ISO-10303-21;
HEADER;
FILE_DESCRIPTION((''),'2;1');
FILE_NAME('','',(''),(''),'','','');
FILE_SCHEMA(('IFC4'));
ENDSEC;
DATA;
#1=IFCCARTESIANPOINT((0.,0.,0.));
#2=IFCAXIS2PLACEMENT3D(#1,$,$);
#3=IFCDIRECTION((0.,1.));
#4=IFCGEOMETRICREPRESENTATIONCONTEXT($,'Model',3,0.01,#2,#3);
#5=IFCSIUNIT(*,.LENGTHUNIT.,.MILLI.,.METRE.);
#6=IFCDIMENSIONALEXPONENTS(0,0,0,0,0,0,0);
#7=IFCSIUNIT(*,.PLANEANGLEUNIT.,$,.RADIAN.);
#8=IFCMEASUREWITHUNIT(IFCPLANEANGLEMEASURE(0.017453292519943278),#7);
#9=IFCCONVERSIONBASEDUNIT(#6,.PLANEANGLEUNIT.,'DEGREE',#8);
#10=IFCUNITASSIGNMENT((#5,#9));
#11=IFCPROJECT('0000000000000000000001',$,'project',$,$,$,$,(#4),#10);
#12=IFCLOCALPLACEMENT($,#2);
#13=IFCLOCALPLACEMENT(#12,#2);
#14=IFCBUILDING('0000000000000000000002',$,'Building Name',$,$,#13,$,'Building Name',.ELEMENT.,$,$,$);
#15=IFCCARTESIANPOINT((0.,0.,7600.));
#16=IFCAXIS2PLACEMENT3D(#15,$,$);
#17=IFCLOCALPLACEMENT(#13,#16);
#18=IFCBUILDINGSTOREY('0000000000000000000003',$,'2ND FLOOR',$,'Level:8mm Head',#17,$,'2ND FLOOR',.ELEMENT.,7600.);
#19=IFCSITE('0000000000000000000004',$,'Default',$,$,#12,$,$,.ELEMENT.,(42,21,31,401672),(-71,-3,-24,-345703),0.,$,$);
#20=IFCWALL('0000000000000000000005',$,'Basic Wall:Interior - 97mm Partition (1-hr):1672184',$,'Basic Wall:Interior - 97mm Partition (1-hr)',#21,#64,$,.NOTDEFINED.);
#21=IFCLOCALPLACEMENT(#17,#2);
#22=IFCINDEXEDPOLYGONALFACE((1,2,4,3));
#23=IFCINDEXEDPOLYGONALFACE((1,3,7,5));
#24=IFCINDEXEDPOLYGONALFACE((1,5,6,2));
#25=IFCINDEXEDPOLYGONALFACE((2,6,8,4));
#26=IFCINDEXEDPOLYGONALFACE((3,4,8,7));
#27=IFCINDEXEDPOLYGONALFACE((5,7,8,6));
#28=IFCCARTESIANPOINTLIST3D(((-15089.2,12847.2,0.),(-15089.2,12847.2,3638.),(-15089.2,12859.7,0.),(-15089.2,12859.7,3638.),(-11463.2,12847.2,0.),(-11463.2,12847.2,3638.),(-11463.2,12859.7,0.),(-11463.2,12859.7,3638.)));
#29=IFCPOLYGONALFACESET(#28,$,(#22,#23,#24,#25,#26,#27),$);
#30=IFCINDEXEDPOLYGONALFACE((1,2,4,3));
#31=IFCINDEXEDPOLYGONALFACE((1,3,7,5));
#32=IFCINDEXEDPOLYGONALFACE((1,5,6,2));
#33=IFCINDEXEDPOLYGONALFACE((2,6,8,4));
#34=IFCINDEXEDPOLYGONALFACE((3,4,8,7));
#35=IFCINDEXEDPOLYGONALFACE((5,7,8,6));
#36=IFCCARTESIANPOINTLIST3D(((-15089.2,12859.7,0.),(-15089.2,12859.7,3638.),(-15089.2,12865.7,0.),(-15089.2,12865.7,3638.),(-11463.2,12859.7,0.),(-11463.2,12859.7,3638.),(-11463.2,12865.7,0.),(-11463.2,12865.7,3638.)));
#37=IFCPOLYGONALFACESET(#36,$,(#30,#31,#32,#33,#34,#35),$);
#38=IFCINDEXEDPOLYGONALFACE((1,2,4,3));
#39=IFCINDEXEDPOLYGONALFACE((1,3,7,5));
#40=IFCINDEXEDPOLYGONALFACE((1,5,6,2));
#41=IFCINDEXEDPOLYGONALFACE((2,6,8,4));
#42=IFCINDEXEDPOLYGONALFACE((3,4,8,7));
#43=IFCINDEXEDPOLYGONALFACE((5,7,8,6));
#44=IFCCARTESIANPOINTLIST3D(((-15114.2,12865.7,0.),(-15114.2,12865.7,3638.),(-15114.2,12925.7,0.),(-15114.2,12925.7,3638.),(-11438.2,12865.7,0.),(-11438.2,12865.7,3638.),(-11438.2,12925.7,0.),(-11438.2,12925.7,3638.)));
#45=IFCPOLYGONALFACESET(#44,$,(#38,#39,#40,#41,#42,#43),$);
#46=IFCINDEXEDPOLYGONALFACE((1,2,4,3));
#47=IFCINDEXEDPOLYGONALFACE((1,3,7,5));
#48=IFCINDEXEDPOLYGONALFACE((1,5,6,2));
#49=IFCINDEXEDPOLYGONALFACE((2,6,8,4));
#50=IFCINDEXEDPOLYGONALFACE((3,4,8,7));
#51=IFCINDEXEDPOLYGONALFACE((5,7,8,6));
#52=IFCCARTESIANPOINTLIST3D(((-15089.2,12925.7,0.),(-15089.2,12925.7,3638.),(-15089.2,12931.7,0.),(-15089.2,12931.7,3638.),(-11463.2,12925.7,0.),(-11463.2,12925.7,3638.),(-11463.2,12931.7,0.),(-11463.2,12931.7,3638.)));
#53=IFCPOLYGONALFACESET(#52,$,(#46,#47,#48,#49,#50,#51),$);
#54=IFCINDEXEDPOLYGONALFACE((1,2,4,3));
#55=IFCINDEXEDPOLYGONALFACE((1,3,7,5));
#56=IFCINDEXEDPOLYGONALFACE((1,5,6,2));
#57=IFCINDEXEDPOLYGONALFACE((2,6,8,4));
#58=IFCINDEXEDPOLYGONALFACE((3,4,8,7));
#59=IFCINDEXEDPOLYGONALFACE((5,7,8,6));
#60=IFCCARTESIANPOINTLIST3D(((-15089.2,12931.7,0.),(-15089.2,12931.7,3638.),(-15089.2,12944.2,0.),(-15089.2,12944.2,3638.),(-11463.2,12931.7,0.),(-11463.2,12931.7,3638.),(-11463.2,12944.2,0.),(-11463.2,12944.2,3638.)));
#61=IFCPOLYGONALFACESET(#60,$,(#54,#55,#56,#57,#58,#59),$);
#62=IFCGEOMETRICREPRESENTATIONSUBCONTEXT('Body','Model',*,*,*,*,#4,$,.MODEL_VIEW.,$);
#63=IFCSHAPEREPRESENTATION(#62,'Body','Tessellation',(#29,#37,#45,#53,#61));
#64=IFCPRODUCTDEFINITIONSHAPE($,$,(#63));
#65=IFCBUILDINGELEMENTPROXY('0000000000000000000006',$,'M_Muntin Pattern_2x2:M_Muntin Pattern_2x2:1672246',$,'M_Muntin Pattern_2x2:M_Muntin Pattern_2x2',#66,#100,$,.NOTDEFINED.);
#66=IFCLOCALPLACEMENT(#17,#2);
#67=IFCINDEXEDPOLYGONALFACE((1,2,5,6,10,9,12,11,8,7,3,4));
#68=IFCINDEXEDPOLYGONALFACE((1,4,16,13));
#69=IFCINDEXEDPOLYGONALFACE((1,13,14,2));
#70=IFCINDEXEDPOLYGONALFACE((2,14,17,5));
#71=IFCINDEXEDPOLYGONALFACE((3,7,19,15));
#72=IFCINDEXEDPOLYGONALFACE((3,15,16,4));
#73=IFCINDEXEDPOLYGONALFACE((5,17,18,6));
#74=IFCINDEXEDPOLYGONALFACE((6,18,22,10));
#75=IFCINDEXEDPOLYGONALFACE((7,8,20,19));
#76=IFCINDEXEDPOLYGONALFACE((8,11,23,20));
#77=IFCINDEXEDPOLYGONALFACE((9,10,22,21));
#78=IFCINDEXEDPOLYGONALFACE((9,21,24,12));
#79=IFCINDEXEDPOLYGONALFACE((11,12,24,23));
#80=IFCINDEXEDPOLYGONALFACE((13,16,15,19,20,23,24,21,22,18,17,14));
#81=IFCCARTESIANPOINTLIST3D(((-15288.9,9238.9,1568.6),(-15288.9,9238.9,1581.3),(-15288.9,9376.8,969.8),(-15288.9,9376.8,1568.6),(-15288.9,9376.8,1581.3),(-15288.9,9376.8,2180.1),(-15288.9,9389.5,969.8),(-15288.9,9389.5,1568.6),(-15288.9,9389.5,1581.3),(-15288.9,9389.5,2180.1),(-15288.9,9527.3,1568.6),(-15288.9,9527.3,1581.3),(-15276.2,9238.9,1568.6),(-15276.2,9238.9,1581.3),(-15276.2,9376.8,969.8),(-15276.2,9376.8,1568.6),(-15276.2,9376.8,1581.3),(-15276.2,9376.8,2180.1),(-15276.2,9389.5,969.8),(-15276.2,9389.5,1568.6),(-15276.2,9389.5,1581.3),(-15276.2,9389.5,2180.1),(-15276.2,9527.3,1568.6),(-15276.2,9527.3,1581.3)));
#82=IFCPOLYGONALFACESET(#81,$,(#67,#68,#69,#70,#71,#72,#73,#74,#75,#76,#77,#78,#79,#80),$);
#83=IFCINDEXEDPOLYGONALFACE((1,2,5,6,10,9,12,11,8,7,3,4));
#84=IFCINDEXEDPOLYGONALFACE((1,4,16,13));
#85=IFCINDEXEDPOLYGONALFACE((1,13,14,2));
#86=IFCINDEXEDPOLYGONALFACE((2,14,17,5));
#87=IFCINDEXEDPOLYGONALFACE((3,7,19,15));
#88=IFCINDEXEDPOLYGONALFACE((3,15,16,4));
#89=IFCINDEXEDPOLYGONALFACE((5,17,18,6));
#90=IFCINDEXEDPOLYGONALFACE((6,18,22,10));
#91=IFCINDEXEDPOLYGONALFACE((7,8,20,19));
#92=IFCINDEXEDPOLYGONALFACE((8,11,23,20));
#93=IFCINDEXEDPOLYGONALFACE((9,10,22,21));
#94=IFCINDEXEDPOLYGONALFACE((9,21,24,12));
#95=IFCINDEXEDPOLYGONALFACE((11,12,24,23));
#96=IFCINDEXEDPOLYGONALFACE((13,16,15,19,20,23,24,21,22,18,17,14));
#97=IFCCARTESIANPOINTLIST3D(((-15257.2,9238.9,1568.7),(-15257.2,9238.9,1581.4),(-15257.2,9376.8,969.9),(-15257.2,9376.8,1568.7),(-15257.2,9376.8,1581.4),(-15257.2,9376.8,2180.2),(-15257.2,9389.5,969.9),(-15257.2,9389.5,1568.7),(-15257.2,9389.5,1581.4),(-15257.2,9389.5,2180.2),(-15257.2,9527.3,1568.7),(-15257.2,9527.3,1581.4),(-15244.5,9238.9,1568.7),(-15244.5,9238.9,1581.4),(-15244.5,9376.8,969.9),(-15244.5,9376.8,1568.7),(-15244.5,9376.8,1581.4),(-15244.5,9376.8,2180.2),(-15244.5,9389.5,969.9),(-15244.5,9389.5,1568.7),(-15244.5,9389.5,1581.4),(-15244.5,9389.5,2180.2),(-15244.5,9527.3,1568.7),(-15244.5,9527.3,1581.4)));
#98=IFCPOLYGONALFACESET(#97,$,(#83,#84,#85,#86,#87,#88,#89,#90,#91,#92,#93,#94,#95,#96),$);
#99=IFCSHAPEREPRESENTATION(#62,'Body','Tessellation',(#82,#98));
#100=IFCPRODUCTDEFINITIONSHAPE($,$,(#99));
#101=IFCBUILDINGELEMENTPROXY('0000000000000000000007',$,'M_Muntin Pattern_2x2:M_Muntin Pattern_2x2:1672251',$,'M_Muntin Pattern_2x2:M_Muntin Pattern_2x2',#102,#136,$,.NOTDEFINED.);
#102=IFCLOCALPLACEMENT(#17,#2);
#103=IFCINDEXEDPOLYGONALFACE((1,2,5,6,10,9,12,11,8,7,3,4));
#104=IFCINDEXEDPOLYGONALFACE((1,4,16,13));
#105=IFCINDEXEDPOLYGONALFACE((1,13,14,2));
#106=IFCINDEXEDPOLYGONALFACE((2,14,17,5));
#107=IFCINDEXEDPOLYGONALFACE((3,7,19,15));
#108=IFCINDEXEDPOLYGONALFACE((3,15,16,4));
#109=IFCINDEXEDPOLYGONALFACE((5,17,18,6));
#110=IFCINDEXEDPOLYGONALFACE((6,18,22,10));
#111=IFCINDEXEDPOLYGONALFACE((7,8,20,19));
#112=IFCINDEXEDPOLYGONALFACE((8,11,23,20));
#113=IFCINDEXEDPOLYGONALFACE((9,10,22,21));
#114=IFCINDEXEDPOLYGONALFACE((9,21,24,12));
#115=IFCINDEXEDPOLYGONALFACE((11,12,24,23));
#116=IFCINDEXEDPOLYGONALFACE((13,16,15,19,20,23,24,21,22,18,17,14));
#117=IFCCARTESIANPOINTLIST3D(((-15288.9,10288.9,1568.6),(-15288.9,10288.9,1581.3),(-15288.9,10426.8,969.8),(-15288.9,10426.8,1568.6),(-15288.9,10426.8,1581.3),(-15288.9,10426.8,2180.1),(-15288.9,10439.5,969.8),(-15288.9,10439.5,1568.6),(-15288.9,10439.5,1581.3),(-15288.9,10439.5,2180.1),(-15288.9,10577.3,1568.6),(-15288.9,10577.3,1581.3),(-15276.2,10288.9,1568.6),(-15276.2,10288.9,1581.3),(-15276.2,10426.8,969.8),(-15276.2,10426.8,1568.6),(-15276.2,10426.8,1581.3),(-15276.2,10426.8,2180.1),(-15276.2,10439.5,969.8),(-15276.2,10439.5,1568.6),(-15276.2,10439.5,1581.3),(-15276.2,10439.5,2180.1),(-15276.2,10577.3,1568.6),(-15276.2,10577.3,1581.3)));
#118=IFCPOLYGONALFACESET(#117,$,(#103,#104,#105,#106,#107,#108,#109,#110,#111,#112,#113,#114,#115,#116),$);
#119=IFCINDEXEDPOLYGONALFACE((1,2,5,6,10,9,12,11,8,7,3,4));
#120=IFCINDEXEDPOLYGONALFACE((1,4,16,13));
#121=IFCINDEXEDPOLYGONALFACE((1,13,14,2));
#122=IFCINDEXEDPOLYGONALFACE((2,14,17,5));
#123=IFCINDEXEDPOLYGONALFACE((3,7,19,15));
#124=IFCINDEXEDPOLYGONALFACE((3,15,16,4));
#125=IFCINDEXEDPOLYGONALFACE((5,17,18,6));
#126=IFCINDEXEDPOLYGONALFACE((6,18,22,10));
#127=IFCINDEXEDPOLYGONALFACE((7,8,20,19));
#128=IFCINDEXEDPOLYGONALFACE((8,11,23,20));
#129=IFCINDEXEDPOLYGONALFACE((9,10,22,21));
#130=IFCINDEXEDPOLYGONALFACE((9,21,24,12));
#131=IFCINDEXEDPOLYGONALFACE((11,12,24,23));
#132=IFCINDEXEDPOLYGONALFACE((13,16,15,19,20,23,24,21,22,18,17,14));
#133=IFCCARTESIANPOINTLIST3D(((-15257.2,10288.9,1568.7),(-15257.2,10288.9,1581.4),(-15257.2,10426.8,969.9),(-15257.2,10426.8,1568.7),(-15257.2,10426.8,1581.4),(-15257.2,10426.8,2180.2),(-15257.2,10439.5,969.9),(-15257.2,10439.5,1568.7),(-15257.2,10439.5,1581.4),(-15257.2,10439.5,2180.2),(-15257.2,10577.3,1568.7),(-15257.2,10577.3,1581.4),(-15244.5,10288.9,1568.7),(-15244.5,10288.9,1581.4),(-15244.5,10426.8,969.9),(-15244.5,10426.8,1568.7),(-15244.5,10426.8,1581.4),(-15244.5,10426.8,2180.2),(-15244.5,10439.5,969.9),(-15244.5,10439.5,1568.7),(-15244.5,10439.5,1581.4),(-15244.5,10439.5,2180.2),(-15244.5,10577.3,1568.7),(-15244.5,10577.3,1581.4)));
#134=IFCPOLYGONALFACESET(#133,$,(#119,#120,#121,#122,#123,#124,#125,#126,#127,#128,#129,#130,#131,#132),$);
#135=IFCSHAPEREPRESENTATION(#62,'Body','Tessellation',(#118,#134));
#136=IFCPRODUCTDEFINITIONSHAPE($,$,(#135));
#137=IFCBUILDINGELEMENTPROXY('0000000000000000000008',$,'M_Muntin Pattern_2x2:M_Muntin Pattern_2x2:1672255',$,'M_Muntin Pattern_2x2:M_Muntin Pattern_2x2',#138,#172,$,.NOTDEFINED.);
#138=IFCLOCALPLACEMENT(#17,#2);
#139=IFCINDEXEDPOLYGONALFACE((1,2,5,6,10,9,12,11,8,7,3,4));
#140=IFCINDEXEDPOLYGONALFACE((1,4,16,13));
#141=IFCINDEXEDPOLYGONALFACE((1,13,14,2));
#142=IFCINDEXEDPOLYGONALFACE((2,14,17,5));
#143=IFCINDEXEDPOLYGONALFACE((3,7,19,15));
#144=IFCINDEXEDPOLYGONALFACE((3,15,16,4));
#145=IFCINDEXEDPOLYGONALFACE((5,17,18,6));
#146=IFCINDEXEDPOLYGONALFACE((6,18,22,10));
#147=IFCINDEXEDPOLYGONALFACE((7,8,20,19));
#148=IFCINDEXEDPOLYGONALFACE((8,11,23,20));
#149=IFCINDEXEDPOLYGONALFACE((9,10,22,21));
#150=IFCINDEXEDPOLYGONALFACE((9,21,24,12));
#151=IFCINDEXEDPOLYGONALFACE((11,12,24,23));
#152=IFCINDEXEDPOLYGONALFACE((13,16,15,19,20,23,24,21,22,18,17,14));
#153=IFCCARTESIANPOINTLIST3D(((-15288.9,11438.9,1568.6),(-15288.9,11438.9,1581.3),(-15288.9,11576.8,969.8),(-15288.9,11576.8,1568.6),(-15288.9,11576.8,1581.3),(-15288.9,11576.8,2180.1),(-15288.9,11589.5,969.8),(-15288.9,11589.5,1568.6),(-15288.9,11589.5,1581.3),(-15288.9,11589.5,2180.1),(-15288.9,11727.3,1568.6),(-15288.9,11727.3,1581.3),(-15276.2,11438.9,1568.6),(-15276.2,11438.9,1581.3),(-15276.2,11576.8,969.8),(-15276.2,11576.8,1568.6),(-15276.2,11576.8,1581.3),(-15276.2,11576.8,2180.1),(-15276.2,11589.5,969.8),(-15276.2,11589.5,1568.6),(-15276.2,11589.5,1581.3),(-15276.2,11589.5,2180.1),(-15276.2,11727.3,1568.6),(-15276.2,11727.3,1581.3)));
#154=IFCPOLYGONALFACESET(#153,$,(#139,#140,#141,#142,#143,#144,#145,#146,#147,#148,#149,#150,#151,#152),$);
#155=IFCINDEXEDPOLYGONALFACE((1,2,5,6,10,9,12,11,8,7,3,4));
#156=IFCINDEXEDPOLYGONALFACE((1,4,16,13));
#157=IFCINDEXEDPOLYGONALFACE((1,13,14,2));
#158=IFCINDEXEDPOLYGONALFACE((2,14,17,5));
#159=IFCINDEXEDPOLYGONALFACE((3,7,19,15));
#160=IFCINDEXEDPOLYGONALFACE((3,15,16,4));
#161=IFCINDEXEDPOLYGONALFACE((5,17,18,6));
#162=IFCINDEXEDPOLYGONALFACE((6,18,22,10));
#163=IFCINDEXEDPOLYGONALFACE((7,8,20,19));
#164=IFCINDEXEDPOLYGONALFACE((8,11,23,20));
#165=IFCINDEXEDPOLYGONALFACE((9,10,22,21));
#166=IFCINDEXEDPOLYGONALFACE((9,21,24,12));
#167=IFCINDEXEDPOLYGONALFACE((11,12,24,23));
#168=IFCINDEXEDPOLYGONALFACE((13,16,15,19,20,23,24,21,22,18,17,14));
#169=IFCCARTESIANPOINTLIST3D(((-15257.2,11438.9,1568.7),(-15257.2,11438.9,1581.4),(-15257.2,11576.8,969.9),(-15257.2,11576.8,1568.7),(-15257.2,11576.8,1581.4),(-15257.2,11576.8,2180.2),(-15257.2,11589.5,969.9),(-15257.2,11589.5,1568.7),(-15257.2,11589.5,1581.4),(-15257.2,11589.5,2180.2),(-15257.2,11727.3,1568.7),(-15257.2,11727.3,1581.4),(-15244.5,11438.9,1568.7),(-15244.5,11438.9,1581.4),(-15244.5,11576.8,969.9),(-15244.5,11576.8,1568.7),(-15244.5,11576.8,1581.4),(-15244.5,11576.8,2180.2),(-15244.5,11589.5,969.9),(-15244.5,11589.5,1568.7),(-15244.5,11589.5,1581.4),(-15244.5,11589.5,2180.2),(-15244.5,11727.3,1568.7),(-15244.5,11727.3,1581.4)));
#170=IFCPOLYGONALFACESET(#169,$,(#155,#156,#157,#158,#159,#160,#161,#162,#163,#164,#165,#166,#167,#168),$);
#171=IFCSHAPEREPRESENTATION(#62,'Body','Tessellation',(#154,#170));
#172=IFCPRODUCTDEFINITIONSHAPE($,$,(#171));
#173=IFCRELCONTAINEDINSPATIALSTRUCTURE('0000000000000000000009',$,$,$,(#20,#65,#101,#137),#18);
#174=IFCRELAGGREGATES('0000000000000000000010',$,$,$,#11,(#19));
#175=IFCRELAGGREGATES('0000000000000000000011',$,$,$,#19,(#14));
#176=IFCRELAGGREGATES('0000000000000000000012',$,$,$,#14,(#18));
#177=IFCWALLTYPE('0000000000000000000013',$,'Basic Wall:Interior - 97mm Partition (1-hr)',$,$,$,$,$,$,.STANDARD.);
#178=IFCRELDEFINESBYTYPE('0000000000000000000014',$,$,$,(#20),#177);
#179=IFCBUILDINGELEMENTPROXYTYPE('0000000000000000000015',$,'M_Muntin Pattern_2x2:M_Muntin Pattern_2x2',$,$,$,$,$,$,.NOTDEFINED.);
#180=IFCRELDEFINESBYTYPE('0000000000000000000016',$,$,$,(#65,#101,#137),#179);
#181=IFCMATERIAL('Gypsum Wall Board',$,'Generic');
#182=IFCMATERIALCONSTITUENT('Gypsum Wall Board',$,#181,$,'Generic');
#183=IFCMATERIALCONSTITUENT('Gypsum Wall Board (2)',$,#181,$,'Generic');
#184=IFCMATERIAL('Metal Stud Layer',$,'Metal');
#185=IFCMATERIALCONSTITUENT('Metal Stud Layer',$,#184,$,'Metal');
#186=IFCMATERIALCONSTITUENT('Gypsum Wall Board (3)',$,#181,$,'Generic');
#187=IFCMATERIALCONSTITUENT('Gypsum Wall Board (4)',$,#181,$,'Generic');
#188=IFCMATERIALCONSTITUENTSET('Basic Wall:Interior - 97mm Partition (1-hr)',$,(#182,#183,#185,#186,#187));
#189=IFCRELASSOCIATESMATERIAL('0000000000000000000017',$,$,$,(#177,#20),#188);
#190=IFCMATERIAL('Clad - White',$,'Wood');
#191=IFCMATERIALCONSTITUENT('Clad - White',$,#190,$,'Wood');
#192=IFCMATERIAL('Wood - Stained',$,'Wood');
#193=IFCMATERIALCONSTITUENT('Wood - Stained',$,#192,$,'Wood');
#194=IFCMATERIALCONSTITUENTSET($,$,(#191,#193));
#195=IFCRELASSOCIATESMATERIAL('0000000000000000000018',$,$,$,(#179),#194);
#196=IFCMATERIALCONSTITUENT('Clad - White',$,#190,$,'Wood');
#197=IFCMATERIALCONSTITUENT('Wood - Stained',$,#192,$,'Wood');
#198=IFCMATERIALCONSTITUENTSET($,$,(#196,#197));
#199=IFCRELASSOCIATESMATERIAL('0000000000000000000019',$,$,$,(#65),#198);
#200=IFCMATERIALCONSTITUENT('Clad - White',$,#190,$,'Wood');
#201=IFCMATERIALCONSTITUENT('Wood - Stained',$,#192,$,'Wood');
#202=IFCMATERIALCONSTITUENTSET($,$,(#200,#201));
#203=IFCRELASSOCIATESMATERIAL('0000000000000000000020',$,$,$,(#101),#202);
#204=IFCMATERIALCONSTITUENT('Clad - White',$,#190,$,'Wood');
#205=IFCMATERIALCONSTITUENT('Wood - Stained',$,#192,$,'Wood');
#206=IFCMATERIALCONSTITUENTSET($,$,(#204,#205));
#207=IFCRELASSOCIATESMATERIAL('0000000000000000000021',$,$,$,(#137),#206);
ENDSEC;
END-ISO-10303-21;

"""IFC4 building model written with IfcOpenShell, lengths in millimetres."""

from ifc_helpers import new_model, entity, si_unit, converted_unit, direction, frame, origin, place, context, subcontext, project, spatial, indexed_curve, outline, extrude, source, transform, mapped, material, constituent, constituent_set, type_object, type_shapes, element, save


model = new_model("IFC4")

# Units and contexts
model_context = context("Model", 3, precision=0.01, world=origin(), true_north=direction((0.0, 1.0)))
body_context = subcontext(model_context, "Body", "Model", "MODEL_VIEW")
ifc_project = project(units=[si_unit("LENGTHUNIT", "METRE", prefix="MILLI"), converted_unit("PLANEANGLEUNIT", "DEGREE", entity("IfcPlaneAngleMeasure", 0.017453292519943278), si_unit("PLANEANGLEUNIT", "RADIAN"), dimensions=[0, 0, 0, 0, 0, 0, 0])], contexts=[model_context])

# Site, building, storey
site_placement = place(None, origin())
site = spatial("IfcSite", under=ifc_project, at=site_placement, Name="Default", CompositionType="ELEMENT", RefLatitude=(42, 21, 31, 401672), RefLongitude=(-71, -3, -24, -345703), RefElevation=0.0)
building_placement = place(site_placement, origin())
building = spatial("IfcBuilding", under=site, at=building_placement, Name="Building Name", LongName="Building Name", CompositionType="ELEMENT")
storey_placement = place(building_placement, frame((0.0, 0.0, 7600.0)))
storey = spatial("IfcBuildingStorey", under=building, at=storey_placement, Name="2ND FLOOR", ObjectType="Level:8mm Head", LongName="2ND FLOOR", CompositionType="ELEMENT", Elevation=7600.0)

# Shared definitions
ifc_material_1 = material(Name="Wood - Stained", Category="Wood")

# Wall
ifc_material_2 = material(Name="Gypsum Wall Board", Category="Generic")
ifc_constituent_1 = constituent(ifc_material_2, Name="Gypsum Wall Board", Category="Generic")
ifc_constituent_2 = constituent(ifc_material_2, Name="Gypsum Wall Board (2)", Category="Generic")
ifc_material_3 = material(Name="Metal Stud Layer", Category="Metal")
ifc_constituent_3 = constituent(ifc_material_3, Name="Metal Stud Layer", Category="Metal")
ifc_constituent_4 = constituent(ifc_material_2, Name="Gypsum Wall Board (3)", Category="Generic")
ifc_constituent_5 = constituent(ifc_material_2, Name="Gypsum Wall Board (4)", Category="Generic")
ifc_constituent_set_1 = constituent_set(constituents=[ifc_constituent_1, ifc_constituent_2, ifc_constituent_3, ifc_constituent_4, ifc_constituent_5], Name="Basic Wall:Interior - 97mm Partition (1-hr)")
wall_type_1 = type_object("IfcWallType", Name="Basic Wall:Interior - 97mm Partition (1-hr)", PredefinedType="STANDARD", material=ifc_constituent_set_1)
wall_1_placement = place(storey_placement, frame((-15089.2, 12895.7, 0.0)))
element("IfcWall", 1, at=wall_1_placement, inside=storey, type_object=wall_type_1, material=ifc_constituent_set_1, Name="Basic Wall:Interior - 97mm Partition (1-hr):1672184", ObjectType="Basic Wall:Interior - 97mm Partition (1-hr)", PredefinedType="NOTDEFINED", context=body_context, shape_type="SweptSolid", body=[
    extrude(outline(indexed_curve([(-6.3, -1813.0), (6.2, -1813.0), (6.3, 1813.0), (-6.2, 1813.0), (-6.3, -1813.0)], self_intersect=False)), frame((1813.0, -42.2, 0.0), z_axis=(0.0, 0.0, 1.0), x_axis=(0.0, 1.0, 0.0)), (0.0, 0.0, 1.0), 3638.0),
    extrude(outline(indexed_curve([(-1813.0, -3.0), (1813.0, -3.0), (1813.0, 3.0), (-1813.0, 3.0), (-1813.0, -3.0)], self_intersect=False)), frame((1813.0, -33.0, 0.0)), (0.0, 0.0, 1.0), 3638.0),
    extrude(outline(indexed_curve([(-1838.0, -30.0), (1838.0, -30.0), (1838.0, 30.0), (-1838.0, 30.0), (-1838.0, -30.0)], self_intersect=False)), frame((1813.0, 0.0, 0.0)), (0.0, 0.0, 1.0), 3638.0),
    extrude(outline(indexed_curve([(-1813.0, -3.0), (1813.0, -3.0), (1813.0, 3.0), (-1813.0, 3.0), (-1813.0, -3.0)], self_intersect=False)), frame((1813.0, 33.0, 0.0)), (0.0, 0.0, 1.0), 3638.0),
    extrude(outline(indexed_curve([(-6.3, -1813.0), (6.2, -1813.0), (6.3, 1813.0), (-6.2, 1813.0), (-6.3, -1813.0)], self_intersect=False)), frame((1813.0, 42.2, 0.0), z_axis=(0.0, 0.0, 1.0), x_axis=(0.0, -1.0, 0.0)), (0.0, 0.0, 1.0), 3638.0),
])

# Building element proxies
ifc_material_4 = material(Name="Clad - White", Category="Wood")
ifc_constituent_6 = constituent(ifc_material_4, Name="Clad - White", Category="Wood")
ifc_constituent_7 = constituent(ifc_material_1, Name="Wood - Stained", Category="Wood")
ifc_constituent_set_2 = constituent_set(constituents=[ifc_constituent_6, ifc_constituent_7])
ifc_constituent_8 = constituent(ifc_material_4, Name="Clad - White", Category="Wood")
ifc_constituent_9 = constituent(ifc_material_1, Name="Wood - Stained", Category="Wood")
ifc_constituent_set_3 = constituent_set(constituents=[ifc_constituent_8, ifc_constituent_9])
building_element_proxy_type_1 = type_object("IfcBuildingElementProxyType", Name="M_Muntin Pattern_2x2:M_Muntin Pattern_2x2", PredefinedType="NOTDEFINED", material=ifc_constituent_set_3)
shared_shape_1 = source(origin(), body_context, "Body", "SweptSolid", [
    extrude(outline(indexed_curve([(6.4, -6.4), (605.1, -6.4), (605.1, 6.3), (6.4, 6.3), (6.4, 144.2), (-6.3, 144.2), (-6.3, 6.3), (-605.2, 6.3), (-605.2, -6.4), (-6.3, -6.4), (-6.3, -144.2), (6.4, -144.2), (6.4, -6.4)], self_intersect=False)), frame((0.0, -22.2, 605.1), z_axis=(0.0, 1.0, 0.0), x_axis=(0.0, 0.0, 1.0)), (0.0, 0.0, 1.0), 12.7),
    extrude(outline(indexed_curve([(6.4, -6.4), (605.2, -6.4), (605.2, 6.3), (6.4, 6.3), (6.4, 144.2), (-6.3, 144.2), (-6.3, 6.3), (-605.2, 6.3), (-605.2, -6.4), (-6.3, -6.4), (-6.3, -144.2), (6.4, -144.2), (6.4, -6.4)], self_intersect=False)), frame((0.0, 9.5, 605.2), z_axis=(0.0, 1.0, 0.0), x_axis=(0.0, 0.0, 1.0)), (0.0, 0.0, 1.0), 12.7),
])
type_shapes(building_element_proxy_type_1, [shared_shape_1])
proxy_1_placement = place(storey_placement, frame((-15266.7, 9383.1, 969.9), z_axis=(0.0, 0.0, 1.0), x_axis=(0.0, -1.0, 0.0)))
element("IfcBuildingElementProxy", 2, at=proxy_1_placement, inside=storey, type_object=building_element_proxy_type_1, material=ifc_constituent_set_2, Name="M_Muntin Pattern_2x2:M_Muntin Pattern_2x2:1672246", ObjectType="M_Muntin Pattern_2x2:M_Muntin Pattern_2x2", PredefinedType="NOTDEFINED", context=body_context, shape_type="MappedRepresentation", body=[
    mapped(shared_shape_1, transform((0.0, 0.0, 0.0), scale=1.0)),
])
ifc_constituent_10 = constituent(ifc_material_4, Name="Clad - White", Category="Wood")
ifc_constituent_11 = constituent(ifc_material_1, Name="Wood - Stained", Category="Wood")
ifc_constituent_set_4 = constituent_set(constituents=[ifc_constituent_10, ifc_constituent_11])
proxy_2_placement = place(storey_placement, frame((-15266.7, 10433.1, 969.9), z_axis=(0.0, 0.0, 1.0), x_axis=(0.0, -1.0, 0.0)))
element("IfcBuildingElementProxy", 3, at=proxy_2_placement, inside=storey, type_object=building_element_proxy_type_1, material=ifc_constituent_set_4, Name="M_Muntin Pattern_2x2:M_Muntin Pattern_2x2:1672251", ObjectType="M_Muntin Pattern_2x2:M_Muntin Pattern_2x2", PredefinedType="NOTDEFINED", context=body_context, shape_type="MappedRepresentation", body=[
    mapped(shared_shape_1, transform((0.0, 0.0, 0.0), scale=1.0)),
])
ifc_constituent_12 = constituent(ifc_material_4, Name="Clad - White", Category="Wood")
ifc_constituent_13 = constituent(ifc_material_1, Name="Wood - Stained", Category="Wood")
ifc_constituent_set_5 = constituent_set(constituents=[ifc_constituent_12, ifc_constituent_13])
proxy_3_placement = place(storey_placement, frame((-15266.7, 11583.1, 969.9), z_axis=(0.0, 0.0, 1.0), x_axis=(0.0, -1.0, 0.0)))
element("IfcBuildingElementProxy", 4, at=proxy_3_placement, inside=storey, type_object=building_element_proxy_type_1, material=ifc_constituent_set_5, Name="M_Muntin Pattern_2x2:M_Muntin Pattern_2x2:1672255", ObjectType="M_Muntin Pattern_2x2:M_Muntin Pattern_2x2", PredefinedType="NOTDEFINED", context=body_context, shape_type="MappedRepresentation", body=[
    mapped(shared_shape_1, transform((0.0, 0.0, 0.0), scale=1.0)),
])

save(model, "model.ifc")
